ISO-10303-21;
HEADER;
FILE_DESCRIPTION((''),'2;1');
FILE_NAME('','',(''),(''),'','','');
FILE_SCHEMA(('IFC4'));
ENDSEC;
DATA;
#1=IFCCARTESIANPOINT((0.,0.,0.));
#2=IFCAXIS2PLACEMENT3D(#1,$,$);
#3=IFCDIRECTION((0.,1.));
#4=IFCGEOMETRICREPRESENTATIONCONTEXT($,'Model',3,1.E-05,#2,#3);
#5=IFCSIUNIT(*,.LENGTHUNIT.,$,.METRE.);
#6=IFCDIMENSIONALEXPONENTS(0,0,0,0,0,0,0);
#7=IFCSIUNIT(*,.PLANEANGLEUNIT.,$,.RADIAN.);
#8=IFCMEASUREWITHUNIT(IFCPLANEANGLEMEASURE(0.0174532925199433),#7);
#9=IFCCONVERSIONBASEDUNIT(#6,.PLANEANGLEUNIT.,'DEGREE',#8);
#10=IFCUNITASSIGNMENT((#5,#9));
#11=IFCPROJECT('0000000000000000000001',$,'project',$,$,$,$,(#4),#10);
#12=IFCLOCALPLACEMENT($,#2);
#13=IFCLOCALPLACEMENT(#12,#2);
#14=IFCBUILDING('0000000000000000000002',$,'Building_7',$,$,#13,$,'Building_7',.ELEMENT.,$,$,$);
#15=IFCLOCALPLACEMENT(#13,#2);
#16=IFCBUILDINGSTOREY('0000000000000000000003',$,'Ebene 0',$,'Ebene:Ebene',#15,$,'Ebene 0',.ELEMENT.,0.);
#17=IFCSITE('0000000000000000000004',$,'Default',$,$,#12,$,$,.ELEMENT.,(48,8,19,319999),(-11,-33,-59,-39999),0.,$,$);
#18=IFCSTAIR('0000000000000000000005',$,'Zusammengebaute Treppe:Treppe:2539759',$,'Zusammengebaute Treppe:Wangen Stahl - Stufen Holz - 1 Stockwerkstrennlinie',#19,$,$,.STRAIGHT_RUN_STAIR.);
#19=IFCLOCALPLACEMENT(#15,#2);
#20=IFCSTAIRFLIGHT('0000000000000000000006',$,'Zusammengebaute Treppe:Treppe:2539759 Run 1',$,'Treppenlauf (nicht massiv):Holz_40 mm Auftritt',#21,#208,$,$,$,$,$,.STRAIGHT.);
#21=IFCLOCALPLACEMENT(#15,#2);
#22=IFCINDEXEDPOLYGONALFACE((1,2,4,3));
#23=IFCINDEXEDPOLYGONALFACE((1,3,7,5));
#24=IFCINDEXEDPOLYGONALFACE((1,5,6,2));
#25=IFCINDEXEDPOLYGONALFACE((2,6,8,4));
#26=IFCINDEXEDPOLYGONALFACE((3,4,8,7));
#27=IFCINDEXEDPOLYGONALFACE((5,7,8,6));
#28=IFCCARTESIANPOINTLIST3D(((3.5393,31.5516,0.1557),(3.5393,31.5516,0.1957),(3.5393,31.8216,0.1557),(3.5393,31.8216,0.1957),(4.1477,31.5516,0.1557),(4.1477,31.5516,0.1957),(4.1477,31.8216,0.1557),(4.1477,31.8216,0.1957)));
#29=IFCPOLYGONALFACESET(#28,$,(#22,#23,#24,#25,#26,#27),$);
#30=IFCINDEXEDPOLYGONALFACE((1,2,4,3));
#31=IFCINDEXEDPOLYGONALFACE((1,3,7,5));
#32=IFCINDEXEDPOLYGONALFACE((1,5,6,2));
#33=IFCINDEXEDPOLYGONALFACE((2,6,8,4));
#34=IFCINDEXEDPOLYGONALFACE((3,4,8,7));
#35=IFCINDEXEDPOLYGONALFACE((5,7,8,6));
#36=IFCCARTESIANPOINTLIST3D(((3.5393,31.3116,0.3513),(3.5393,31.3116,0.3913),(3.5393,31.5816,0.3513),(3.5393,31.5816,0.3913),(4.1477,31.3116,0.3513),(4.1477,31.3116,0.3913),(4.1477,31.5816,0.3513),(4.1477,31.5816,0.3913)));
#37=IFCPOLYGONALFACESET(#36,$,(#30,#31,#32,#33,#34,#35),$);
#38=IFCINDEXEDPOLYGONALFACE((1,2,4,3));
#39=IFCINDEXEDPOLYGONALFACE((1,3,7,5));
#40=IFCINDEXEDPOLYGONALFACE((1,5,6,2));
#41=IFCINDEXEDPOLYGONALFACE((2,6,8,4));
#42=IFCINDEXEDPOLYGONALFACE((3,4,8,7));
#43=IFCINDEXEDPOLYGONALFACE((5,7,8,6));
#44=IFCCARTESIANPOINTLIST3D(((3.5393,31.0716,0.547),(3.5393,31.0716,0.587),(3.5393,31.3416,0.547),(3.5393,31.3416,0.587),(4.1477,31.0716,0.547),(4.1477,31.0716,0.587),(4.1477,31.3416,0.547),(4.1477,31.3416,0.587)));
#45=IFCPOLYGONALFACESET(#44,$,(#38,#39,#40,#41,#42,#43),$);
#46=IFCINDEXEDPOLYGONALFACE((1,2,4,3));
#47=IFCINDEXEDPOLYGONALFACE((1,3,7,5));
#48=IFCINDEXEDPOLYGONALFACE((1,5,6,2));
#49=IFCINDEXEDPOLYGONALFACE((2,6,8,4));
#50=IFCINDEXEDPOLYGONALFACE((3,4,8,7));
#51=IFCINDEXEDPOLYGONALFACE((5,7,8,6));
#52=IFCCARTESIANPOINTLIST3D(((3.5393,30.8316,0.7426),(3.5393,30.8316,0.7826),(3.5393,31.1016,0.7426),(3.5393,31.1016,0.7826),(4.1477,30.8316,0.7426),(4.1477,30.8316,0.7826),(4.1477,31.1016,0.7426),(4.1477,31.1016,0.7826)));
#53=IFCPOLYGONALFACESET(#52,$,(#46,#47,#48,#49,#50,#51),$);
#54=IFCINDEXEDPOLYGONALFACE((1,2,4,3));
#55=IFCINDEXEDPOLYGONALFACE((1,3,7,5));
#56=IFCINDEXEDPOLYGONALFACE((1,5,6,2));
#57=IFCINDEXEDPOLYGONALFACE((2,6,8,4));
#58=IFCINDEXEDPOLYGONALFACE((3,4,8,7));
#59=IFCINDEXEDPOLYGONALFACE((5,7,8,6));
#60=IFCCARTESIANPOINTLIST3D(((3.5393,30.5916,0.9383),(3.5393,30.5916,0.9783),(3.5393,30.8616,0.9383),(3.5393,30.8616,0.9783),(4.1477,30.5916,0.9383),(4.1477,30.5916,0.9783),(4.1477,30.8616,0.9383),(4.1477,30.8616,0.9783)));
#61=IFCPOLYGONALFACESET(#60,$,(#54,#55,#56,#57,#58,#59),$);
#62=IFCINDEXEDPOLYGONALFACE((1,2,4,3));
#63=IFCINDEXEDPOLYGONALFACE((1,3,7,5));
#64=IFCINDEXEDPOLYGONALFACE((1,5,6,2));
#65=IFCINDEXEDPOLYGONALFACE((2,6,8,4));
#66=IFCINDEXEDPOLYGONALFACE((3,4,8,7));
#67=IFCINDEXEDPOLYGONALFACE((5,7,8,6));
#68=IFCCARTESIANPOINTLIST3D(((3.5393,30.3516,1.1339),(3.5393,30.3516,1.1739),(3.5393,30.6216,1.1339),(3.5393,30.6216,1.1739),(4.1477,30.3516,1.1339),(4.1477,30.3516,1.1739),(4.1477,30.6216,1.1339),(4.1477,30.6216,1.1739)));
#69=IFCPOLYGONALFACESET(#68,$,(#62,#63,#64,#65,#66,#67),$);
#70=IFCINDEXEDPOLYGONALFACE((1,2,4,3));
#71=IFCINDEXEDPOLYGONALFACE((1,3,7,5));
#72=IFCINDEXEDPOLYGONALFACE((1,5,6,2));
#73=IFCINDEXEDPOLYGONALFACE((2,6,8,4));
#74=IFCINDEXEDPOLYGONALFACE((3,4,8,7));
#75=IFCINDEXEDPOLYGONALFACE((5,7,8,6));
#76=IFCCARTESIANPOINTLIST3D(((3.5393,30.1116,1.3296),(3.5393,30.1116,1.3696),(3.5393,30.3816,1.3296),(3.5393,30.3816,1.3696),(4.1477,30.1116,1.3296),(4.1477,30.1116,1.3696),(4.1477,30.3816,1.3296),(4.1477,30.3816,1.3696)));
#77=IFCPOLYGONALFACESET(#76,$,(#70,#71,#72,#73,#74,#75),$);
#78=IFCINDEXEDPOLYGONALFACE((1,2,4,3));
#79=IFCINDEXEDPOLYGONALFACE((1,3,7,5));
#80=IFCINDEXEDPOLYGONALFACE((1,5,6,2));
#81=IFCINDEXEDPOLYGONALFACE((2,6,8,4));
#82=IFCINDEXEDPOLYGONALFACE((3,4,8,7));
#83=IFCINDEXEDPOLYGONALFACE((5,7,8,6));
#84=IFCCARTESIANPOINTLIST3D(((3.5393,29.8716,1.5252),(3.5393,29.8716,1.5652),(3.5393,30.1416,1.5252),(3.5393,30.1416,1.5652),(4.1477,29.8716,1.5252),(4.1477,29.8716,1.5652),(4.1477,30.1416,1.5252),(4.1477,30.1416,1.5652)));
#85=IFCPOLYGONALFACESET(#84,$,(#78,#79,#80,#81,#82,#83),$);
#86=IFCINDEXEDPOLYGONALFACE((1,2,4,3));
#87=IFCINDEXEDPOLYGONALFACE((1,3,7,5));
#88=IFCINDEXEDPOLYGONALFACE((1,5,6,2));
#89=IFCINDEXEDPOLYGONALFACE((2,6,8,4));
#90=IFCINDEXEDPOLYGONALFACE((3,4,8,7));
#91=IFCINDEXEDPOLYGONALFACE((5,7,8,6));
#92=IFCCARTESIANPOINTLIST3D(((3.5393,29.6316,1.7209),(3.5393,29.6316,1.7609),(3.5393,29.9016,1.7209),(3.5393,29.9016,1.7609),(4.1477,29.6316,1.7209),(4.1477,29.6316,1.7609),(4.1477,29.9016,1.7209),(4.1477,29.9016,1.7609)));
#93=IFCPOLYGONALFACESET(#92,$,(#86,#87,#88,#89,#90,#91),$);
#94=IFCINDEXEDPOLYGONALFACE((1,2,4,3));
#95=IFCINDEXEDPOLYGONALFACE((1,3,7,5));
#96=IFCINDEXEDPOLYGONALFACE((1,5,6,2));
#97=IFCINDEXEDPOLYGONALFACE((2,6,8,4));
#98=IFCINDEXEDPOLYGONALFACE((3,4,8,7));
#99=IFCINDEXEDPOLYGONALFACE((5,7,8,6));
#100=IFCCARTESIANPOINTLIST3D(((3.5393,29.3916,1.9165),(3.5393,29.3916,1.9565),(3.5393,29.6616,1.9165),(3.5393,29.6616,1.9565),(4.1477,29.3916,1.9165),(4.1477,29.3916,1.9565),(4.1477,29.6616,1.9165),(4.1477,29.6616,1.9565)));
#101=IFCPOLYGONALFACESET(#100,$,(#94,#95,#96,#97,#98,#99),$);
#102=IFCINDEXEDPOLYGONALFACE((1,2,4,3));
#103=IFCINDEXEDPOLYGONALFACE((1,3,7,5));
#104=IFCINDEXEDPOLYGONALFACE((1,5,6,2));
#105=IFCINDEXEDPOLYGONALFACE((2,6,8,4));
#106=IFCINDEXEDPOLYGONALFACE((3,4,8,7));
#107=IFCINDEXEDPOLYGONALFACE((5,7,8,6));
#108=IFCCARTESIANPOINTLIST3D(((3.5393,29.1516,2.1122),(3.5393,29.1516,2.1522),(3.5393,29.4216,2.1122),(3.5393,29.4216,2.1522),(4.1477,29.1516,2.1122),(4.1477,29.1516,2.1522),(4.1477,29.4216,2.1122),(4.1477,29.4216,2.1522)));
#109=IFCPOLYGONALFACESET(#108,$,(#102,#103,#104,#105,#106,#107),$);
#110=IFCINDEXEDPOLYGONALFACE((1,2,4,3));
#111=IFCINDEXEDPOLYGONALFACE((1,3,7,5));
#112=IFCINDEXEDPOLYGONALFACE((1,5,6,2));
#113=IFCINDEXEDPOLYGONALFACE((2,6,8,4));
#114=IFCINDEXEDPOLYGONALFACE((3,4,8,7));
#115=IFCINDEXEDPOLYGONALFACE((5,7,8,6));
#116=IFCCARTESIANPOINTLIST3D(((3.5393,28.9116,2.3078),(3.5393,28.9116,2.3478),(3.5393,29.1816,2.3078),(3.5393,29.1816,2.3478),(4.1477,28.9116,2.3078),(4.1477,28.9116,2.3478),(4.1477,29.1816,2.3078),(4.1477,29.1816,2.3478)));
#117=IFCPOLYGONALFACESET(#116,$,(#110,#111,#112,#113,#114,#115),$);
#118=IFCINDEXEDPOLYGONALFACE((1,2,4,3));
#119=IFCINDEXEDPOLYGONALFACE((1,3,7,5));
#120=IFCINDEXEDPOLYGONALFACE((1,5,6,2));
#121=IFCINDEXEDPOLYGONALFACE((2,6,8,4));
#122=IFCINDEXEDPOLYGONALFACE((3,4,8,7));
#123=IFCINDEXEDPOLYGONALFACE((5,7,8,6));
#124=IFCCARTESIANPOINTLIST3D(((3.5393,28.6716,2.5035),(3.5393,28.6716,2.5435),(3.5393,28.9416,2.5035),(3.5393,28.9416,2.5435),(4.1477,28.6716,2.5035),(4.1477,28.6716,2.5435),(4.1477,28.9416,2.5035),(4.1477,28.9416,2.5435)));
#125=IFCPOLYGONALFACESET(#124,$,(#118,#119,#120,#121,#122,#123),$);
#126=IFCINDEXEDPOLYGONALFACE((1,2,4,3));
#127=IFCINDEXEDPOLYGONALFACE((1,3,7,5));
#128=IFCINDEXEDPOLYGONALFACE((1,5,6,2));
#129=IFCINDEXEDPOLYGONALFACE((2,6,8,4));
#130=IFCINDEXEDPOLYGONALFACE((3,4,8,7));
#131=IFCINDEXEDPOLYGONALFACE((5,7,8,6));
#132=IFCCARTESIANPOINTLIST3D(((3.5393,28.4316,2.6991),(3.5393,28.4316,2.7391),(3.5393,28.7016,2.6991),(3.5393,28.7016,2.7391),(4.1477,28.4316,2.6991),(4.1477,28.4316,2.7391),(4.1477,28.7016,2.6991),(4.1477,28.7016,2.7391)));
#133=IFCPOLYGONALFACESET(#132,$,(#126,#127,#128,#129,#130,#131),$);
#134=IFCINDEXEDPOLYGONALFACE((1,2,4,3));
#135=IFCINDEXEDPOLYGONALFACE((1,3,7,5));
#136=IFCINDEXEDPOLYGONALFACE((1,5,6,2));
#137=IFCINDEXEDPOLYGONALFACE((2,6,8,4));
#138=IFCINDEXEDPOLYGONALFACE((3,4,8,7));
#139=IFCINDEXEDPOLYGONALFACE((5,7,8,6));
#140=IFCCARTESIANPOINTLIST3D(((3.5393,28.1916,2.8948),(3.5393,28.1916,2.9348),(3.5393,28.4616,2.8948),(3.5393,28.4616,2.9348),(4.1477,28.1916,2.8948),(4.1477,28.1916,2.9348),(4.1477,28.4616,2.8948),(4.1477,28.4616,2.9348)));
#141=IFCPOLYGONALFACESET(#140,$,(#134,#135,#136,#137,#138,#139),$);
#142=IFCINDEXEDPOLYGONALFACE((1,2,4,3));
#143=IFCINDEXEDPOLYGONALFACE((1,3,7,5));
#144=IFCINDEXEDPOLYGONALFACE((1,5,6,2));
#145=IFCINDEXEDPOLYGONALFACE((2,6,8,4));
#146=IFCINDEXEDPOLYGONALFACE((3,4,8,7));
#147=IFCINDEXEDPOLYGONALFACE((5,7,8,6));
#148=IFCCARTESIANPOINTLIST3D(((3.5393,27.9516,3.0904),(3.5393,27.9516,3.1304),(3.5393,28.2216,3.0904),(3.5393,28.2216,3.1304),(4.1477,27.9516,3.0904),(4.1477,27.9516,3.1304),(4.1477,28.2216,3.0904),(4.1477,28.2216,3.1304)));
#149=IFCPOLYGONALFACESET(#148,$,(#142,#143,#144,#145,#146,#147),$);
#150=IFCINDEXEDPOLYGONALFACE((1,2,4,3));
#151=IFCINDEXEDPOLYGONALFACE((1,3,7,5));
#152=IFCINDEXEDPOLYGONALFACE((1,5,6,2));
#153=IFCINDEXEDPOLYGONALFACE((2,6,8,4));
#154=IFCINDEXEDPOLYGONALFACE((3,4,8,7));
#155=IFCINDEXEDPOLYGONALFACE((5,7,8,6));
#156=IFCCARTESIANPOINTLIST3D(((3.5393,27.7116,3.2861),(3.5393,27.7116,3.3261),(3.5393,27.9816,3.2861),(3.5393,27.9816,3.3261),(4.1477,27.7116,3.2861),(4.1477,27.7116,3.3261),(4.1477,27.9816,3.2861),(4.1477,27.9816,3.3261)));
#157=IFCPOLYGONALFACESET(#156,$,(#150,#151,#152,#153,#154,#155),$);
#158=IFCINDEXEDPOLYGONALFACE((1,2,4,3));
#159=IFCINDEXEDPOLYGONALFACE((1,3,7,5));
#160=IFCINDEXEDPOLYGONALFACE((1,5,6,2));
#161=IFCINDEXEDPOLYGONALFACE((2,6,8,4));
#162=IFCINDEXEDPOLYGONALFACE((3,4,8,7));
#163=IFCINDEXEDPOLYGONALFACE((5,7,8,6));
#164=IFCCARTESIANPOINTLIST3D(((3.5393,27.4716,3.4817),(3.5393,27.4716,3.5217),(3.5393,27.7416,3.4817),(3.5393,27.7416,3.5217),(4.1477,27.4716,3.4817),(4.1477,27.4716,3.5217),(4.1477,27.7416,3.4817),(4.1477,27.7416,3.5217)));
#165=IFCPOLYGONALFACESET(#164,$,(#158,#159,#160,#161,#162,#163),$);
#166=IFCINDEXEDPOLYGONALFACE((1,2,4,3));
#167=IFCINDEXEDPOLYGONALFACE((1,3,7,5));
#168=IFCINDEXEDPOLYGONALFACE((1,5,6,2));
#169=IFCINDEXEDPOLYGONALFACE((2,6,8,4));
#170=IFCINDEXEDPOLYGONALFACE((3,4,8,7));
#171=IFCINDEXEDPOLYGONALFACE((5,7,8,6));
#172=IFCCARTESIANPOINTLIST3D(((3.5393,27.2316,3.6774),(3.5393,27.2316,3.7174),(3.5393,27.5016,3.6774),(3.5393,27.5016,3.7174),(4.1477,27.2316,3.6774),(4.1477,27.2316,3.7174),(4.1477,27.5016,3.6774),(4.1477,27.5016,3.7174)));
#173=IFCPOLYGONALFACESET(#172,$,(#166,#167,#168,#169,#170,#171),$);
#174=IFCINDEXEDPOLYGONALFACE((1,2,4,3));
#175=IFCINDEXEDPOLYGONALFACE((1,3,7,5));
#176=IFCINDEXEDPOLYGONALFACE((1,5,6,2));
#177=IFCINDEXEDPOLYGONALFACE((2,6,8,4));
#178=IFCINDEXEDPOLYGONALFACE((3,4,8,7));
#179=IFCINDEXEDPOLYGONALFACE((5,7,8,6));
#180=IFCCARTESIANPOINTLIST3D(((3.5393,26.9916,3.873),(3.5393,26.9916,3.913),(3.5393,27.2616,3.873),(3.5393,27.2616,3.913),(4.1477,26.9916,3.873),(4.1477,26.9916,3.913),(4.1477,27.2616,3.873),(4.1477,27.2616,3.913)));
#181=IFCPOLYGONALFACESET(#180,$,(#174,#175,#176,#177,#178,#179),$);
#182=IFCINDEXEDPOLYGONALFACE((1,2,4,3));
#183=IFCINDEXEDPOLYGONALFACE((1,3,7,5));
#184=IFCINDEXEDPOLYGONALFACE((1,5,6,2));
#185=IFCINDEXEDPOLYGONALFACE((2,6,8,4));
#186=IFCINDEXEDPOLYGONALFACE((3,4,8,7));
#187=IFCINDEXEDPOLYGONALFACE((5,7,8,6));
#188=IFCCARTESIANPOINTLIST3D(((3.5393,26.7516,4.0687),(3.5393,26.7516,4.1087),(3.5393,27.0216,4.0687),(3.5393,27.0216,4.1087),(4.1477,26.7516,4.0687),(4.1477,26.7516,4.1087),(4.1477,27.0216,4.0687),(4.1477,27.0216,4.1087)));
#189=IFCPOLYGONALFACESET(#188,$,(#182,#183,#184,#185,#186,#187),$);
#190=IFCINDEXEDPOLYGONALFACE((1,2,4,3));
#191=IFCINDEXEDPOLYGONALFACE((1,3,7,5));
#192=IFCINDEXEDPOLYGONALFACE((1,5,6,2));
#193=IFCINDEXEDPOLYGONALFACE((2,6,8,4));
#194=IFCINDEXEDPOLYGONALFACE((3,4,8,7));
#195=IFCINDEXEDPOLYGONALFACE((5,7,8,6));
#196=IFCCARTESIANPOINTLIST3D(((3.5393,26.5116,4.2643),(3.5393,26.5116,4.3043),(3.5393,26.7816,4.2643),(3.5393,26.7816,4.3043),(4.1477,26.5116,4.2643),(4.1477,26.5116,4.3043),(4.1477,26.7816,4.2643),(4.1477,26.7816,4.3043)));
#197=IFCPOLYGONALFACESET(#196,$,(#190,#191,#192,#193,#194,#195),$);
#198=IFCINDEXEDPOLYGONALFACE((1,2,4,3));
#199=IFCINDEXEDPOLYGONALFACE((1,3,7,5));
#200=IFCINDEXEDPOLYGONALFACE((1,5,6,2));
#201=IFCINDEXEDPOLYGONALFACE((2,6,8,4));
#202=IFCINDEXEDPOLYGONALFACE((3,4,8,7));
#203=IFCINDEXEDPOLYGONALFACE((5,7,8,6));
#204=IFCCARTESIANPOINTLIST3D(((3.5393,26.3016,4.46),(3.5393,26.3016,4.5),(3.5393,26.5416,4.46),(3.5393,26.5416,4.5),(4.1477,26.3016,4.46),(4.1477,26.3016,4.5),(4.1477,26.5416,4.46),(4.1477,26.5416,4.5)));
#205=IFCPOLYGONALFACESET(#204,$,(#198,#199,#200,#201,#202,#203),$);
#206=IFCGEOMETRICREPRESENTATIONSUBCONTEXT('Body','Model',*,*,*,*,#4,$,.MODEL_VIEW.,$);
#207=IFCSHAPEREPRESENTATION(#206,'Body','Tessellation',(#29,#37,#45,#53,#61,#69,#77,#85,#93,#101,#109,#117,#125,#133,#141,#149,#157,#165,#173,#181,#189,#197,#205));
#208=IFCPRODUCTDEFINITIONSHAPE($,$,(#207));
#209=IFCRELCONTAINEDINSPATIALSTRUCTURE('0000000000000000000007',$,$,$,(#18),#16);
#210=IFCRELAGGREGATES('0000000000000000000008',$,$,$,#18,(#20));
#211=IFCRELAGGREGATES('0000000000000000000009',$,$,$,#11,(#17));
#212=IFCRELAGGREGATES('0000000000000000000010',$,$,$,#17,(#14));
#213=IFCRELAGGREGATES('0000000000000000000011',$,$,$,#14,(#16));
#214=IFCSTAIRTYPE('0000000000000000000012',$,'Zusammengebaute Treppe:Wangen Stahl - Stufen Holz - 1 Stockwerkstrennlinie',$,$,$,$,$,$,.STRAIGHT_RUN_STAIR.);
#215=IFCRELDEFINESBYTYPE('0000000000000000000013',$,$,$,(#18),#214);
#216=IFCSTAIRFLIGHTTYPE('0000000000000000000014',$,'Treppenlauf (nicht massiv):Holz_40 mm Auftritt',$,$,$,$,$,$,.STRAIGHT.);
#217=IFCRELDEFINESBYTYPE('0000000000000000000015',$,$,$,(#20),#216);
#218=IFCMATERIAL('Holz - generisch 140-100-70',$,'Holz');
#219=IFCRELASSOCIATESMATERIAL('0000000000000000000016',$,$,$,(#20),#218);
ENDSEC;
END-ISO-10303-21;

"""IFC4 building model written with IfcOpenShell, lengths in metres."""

from ifc_helpers import new_model, entity, si_unit, converted_unit, direction, frame, origin, place, context, subcontext, project, spatial, indexed_curve, outline, extrude, material, type_object, element, aggregate, save


model = new_model("IFC4")

# Units and contexts
model_context = context("Model", 3, precision=1e-05, world=origin(), true_north=direction((0.0, 1.0)))
body_context = subcontext(model_context, "Body", "Model", "MODEL_VIEW")
ifc_project = project(units=[si_unit("LENGTHUNIT", "METRE"), converted_unit("PLANEANGLEUNIT", "DEGREE", entity("IfcPlaneAngleMeasure", 0.0174532925199433), si_unit("PLANEANGLEUNIT", "RADIAN"), dimensions=[0, 0, 0, 0, 0, 0, 0])], contexts=[model_context])

# Site, building, storey
site_placement = place(None, origin())
site = spatial("IfcSite", under=ifc_project, at=site_placement, Name="Default", CompositionType="ELEMENT", RefLatitude=(48, 8, 19, 319999), RefLongitude=(-11, -33, -59, -39999), RefElevation=0.0)
building_placement = place(site_placement, origin())
building = spatial("IfcBuilding", under=site, at=building_placement, Name="Building_7", LongName="Building_7", CompositionType="ELEMENT")
storey_placement = place(building_placement, origin())
storey = spatial("IfcBuildingStorey", under=building, at=storey_placement, Name="Ebene 0", ObjectType="Ebene:Ebene", LongName="Ebene 0", CompositionType="ELEMENT", Elevation=0.0)

# Stair
stair_type = type_object("IfcStairType", Name="Zusammengebaute Treppe:Wangen Stahl - Stufen Holz - 1 Stockwerkstrennlinie", PredefinedType="STRAIGHT_RUN_STAIR")
stair_placement = place(storey_placement, origin())
stair = element("IfcStair", 1, at=stair_placement, inside=storey, type_object=stair_type, Name="Zusammengebaute Treppe:Treppe:2539759", ObjectType="Zusammengebaute Treppe:Wangen Stahl - Stufen Holz - 1 Stockwerkstrennlinie", PredefinedType="STRAIGHT_RUN_STAIR")

# Stair flight
ifc_material_1 = material(Name="Holz - generisch 140-100-70", Category="Holz")
stair_flight_type = type_object("IfcStairFlightType", Name="Treppenlauf (nicht massiv):Holz_40 mm Auftritt", PredefinedType="STRAIGHT")
stair_flight_placement = place(stair_placement, origin())
stair_flight = element("IfcStairFlight", 2, at=stair_flight_placement, type_object=stair_flight_type, material=ifc_material_1, Name="Zusammengebaute Treppe:Treppe:2539759 Run 1", ObjectType="Treppenlauf (nicht massiv):Holz_40 mm Auftritt", PredefinedType="STRAIGHT", context=body_context, shape_type="SweptSolid", body=[
    extrude(outline(indexed_curve([(-0.135, -0.3042), (0.135, -0.3042), (0.135, 0.3042), (-0.135, 0.3042), (-0.135, -0.3042)], self_intersect=False)), frame((3.8435, 31.6866, 0.1557), z_axis=(0.0, 0.0, 1.0), x_axis=(0.0, 1.0, 0.0)), (0.0, 0.0, 1.0), 0.04),
    extrude(outline(indexed_curve([(-0.135, -0.3042), (0.135, -0.3042), (0.135, 0.3042), (-0.135, 0.3042), (-0.135, -0.3042)], self_intersect=False)), frame((3.8435, 31.4466, 0.3513), z_axis=(0.0, 0.0, 1.0), x_axis=(0.0, 1.0, 0.0)), (0.0, 0.0, 1.0), 0.04),
    extrude(outline(indexed_curve([(-0.135, -0.3042), (0.135, -0.3042), (0.135, 0.3042), (-0.135, 0.3042), (-0.135, -0.3042)], self_intersect=False)), frame((3.8435, 31.2066, 0.547), z_axis=(0.0, 0.0, 1.0), x_axis=(0.0, 1.0, 0.0)), (0.0, 0.0, 1.0), 0.04),
    extrude(outline(indexed_curve([(-0.135, -0.3042), (0.135, -0.3042), (0.135, 0.3042), (-0.135, 0.3042), (-0.135, -0.3042)], self_intersect=False)), frame((3.8435, 30.9666, 0.7426), z_axis=(0.0, 0.0, 1.0), x_axis=(0.0, 1.0, 0.0)), (0.0, 0.0, 1.0), 0.04),
    extrude(outline(indexed_curve([(-0.135, -0.3042), (0.135, -0.3042), (0.135, 0.3042), (-0.135, 0.3042), (-0.135, -0.3042)], self_intersect=False)), frame((3.8435, 30.7266, 0.9383), z_axis=(0.0, 0.0, 1.0), x_axis=(0.0, 1.0, 0.0)), (0.0, 0.0, 1.0), 0.04),
    extrude(outline(indexed_curve([(-0.135, -0.3042), (0.135, -0.3042), (0.135, 0.3042), (-0.135, 0.3042), (-0.135, -0.3042)], self_intersect=False)), frame((3.8435, 30.4866, 1.1339), z_axis=(0.0, 0.0, 1.0), x_axis=(0.0, 1.0, 0.0)), (0.0, 0.0, 1.0), 0.04),
    extrude(outline(indexed_curve([(-0.135, -0.3042), (0.135, -0.3042), (0.135, 0.3042), (-0.135, 0.3042), (-0.135, -0.3042)], self_intersect=False)), frame((3.8435, 30.2466, 1.3296), z_axis=(0.0, 0.0, 1.0), x_axis=(0.0, 1.0, 0.0)), (0.0, 0.0, 1.0), 0.04),
    extrude(outline(indexed_curve([(-0.135, -0.3042), (0.135, -0.3042), (0.135, 0.3042), (-0.135, 0.3042), (-0.135, -0.3042)], self_intersect=False)), frame((3.8435, 30.0066, 1.5252), z_axis=(0.0, 0.0, 1.0), x_axis=(0.0, 1.0, 0.0)), (0.0, 0.0, 1.0), 0.04),
    extrude(outline(indexed_curve([(-0.135, -0.3042), (0.135, -0.3042), (0.135, 0.3042), (-0.135, 0.3042), (-0.135, -0.3042)], self_intersect=False)), frame((3.8435, 29.7666, 1.7209), z_axis=(0.0, 0.0, 1.0), x_axis=(0.0, 1.0, 0.0)), (0.0, 0.0, 1.0), 0.04),
    extrude(outline(indexed_curve([(-0.135, -0.3042), (0.135, -0.3042), (0.135, 0.3042), (-0.135, 0.3042), (-0.135, -0.3042)], self_intersect=False)), frame((3.8435, 29.5266, 1.9165), z_axis=(0.0, 0.0, 1.0), x_axis=(0.0, 1.0, 0.0)), (0.0, 0.0, 1.0), 0.04),
    extrude(outline(indexed_curve([(-0.135, -0.3042), (0.135, -0.3042), (0.135, 0.3042), (-0.135, 0.3042), (-0.135, -0.3042)], self_intersect=False)), frame((3.8435, 29.2866, 2.1122), z_axis=(0.0, 0.0, 1.0), x_axis=(0.0, 1.0, 0.0)), (0.0, 0.0, 1.0), 0.04),
    extrude(outline(indexed_curve([(-0.135, -0.3042), (0.135, -0.3042), (0.135, 0.3042), (-0.135, 0.3042), (-0.135, -0.3042)], self_intersect=False)), frame((3.8435, 29.0466, 2.3078), z_axis=(0.0, 0.0, 1.0), x_axis=(0.0, 1.0, 0.0)), (0.0, 0.0, 1.0), 0.04),
    extrude(outline(indexed_curve([(-0.135, -0.3042), (0.135, -0.3042), (0.135, 0.3042), (-0.135, 0.3042), (-0.135, -0.3042)], self_intersect=False)), frame((3.8435, 28.8066, 2.5035), z_axis=(0.0, 0.0, 1.0), x_axis=(0.0, 1.0, 0.0)), (0.0, 0.0, 1.0), 0.04),
    extrude(outline(indexed_curve([(-0.135, -0.3042), (0.135, -0.3042), (0.135, 0.3042), (-0.135, 0.3042), (-0.135, -0.3042)], self_intersect=False)), frame((3.8435, 28.5666, 2.6991), z_axis=(0.0, 0.0, 1.0), x_axis=(0.0, 1.0, 0.0)), (0.0, 0.0, 1.0), 0.04),
    extrude(outline(indexed_curve([(-0.135, -0.3042), (0.135, -0.3042), (0.135, 0.3042), (-0.135, 0.3042), (-0.135, -0.3042)], self_intersect=False)), frame((3.8435, 28.3266, 2.8948), z_axis=(0.0, 0.0, 1.0), x_axis=(0.0, 1.0, 0.0)), (0.0, 0.0, 1.0), 0.04),
    extrude(outline(indexed_curve([(-0.135, -0.3042), (0.135, -0.3042), (0.135, 0.3042), (-0.135, 0.3042), (-0.135, -0.3042)], self_intersect=False)), frame((3.8435, 28.0866, 3.0904), z_axis=(0.0, 0.0, 1.0), x_axis=(0.0, 1.0, 0.0)), (0.0, 0.0, 1.0), 0.04),
    extrude(outline(indexed_curve([(-0.135, -0.3042), (0.135, -0.3042), (0.135, 0.3042), (-0.135, 0.3042), (-0.135, -0.3042)], self_intersect=False)), frame((3.8435, 27.8466, 3.2861), z_axis=(0.0, 0.0, 1.0), x_axis=(0.0, 1.0, 0.0)), (0.0, 0.0, 1.0), 0.04),
    extrude(outline(indexed_curve([(-0.135, -0.3042), (0.135, -0.3042), (0.135, 0.3042), (-0.135, 0.3042), (-0.135, -0.3042)], self_intersect=False)), frame((3.8435, 27.6066, 3.4817), z_axis=(0.0, 0.0, 1.0), x_axis=(0.0, 1.0, 0.0)), (0.0, 0.0, 1.0), 0.04),
    extrude(outline(indexed_curve([(-0.135, -0.3042), (0.135, -0.3042), (0.135, 0.3042), (-0.135, 0.3042), (-0.135, -0.3042)], self_intersect=False)), frame((3.8435, 27.3666, 3.6774), z_axis=(0.0, 0.0, 1.0), x_axis=(0.0, 1.0, 0.0)), (0.0, 0.0, 1.0), 0.04),
    extrude(outline(indexed_curve([(-0.135, -0.3042), (0.135, -0.3042), (0.135, 0.3042), (-0.135, 0.3042), (-0.135, -0.3042)], self_intersect=False)), frame((3.8435, 27.1266, 3.873), z_axis=(0.0, 0.0, 1.0), x_axis=(0.0, 1.0, 0.0)), (0.0, 0.0, 1.0), 0.04),
    extrude(outline(indexed_curve([(-0.135, -0.3042), (0.135, -0.3042), (0.135, 0.3042), (-0.135, 0.3042), (-0.135, -0.3042)], self_intersect=False)), frame((3.8435, 26.8866, 4.0687), z_axis=(0.0, 0.0, 1.0), x_axis=(0.0, 1.0, 0.0)), (0.0, 0.0, 1.0), 0.04),
    extrude(outline(indexed_curve([(-0.135, -0.3042), (0.135, -0.3042), (0.135, 0.3042), (-0.135, 0.3042), (-0.135, -0.3042)], self_intersect=False)), frame((3.8435, 26.6466, 4.2643), z_axis=(0.0, 0.0, 1.0), x_axis=(0.0, 1.0, 0.0)), (0.0, 0.0, 1.0), 0.04),
    extrude(outline(indexed_curve([(-0.12, -0.3042), (0.12, -0.3042), (0.12, 0.3042), (-0.12, 0.3042), (-0.12, -0.3042)], self_intersect=False)), frame((3.8435, 26.4216, 4.46), z_axis=(0.0, 0.0, 1.0), x_axis=(0.0, 1.0, 0.0)), (0.0, 0.0, 1.0), 0.04),
])
aggregate(stair, [stair_flight])

save(model, "model.ifc")
